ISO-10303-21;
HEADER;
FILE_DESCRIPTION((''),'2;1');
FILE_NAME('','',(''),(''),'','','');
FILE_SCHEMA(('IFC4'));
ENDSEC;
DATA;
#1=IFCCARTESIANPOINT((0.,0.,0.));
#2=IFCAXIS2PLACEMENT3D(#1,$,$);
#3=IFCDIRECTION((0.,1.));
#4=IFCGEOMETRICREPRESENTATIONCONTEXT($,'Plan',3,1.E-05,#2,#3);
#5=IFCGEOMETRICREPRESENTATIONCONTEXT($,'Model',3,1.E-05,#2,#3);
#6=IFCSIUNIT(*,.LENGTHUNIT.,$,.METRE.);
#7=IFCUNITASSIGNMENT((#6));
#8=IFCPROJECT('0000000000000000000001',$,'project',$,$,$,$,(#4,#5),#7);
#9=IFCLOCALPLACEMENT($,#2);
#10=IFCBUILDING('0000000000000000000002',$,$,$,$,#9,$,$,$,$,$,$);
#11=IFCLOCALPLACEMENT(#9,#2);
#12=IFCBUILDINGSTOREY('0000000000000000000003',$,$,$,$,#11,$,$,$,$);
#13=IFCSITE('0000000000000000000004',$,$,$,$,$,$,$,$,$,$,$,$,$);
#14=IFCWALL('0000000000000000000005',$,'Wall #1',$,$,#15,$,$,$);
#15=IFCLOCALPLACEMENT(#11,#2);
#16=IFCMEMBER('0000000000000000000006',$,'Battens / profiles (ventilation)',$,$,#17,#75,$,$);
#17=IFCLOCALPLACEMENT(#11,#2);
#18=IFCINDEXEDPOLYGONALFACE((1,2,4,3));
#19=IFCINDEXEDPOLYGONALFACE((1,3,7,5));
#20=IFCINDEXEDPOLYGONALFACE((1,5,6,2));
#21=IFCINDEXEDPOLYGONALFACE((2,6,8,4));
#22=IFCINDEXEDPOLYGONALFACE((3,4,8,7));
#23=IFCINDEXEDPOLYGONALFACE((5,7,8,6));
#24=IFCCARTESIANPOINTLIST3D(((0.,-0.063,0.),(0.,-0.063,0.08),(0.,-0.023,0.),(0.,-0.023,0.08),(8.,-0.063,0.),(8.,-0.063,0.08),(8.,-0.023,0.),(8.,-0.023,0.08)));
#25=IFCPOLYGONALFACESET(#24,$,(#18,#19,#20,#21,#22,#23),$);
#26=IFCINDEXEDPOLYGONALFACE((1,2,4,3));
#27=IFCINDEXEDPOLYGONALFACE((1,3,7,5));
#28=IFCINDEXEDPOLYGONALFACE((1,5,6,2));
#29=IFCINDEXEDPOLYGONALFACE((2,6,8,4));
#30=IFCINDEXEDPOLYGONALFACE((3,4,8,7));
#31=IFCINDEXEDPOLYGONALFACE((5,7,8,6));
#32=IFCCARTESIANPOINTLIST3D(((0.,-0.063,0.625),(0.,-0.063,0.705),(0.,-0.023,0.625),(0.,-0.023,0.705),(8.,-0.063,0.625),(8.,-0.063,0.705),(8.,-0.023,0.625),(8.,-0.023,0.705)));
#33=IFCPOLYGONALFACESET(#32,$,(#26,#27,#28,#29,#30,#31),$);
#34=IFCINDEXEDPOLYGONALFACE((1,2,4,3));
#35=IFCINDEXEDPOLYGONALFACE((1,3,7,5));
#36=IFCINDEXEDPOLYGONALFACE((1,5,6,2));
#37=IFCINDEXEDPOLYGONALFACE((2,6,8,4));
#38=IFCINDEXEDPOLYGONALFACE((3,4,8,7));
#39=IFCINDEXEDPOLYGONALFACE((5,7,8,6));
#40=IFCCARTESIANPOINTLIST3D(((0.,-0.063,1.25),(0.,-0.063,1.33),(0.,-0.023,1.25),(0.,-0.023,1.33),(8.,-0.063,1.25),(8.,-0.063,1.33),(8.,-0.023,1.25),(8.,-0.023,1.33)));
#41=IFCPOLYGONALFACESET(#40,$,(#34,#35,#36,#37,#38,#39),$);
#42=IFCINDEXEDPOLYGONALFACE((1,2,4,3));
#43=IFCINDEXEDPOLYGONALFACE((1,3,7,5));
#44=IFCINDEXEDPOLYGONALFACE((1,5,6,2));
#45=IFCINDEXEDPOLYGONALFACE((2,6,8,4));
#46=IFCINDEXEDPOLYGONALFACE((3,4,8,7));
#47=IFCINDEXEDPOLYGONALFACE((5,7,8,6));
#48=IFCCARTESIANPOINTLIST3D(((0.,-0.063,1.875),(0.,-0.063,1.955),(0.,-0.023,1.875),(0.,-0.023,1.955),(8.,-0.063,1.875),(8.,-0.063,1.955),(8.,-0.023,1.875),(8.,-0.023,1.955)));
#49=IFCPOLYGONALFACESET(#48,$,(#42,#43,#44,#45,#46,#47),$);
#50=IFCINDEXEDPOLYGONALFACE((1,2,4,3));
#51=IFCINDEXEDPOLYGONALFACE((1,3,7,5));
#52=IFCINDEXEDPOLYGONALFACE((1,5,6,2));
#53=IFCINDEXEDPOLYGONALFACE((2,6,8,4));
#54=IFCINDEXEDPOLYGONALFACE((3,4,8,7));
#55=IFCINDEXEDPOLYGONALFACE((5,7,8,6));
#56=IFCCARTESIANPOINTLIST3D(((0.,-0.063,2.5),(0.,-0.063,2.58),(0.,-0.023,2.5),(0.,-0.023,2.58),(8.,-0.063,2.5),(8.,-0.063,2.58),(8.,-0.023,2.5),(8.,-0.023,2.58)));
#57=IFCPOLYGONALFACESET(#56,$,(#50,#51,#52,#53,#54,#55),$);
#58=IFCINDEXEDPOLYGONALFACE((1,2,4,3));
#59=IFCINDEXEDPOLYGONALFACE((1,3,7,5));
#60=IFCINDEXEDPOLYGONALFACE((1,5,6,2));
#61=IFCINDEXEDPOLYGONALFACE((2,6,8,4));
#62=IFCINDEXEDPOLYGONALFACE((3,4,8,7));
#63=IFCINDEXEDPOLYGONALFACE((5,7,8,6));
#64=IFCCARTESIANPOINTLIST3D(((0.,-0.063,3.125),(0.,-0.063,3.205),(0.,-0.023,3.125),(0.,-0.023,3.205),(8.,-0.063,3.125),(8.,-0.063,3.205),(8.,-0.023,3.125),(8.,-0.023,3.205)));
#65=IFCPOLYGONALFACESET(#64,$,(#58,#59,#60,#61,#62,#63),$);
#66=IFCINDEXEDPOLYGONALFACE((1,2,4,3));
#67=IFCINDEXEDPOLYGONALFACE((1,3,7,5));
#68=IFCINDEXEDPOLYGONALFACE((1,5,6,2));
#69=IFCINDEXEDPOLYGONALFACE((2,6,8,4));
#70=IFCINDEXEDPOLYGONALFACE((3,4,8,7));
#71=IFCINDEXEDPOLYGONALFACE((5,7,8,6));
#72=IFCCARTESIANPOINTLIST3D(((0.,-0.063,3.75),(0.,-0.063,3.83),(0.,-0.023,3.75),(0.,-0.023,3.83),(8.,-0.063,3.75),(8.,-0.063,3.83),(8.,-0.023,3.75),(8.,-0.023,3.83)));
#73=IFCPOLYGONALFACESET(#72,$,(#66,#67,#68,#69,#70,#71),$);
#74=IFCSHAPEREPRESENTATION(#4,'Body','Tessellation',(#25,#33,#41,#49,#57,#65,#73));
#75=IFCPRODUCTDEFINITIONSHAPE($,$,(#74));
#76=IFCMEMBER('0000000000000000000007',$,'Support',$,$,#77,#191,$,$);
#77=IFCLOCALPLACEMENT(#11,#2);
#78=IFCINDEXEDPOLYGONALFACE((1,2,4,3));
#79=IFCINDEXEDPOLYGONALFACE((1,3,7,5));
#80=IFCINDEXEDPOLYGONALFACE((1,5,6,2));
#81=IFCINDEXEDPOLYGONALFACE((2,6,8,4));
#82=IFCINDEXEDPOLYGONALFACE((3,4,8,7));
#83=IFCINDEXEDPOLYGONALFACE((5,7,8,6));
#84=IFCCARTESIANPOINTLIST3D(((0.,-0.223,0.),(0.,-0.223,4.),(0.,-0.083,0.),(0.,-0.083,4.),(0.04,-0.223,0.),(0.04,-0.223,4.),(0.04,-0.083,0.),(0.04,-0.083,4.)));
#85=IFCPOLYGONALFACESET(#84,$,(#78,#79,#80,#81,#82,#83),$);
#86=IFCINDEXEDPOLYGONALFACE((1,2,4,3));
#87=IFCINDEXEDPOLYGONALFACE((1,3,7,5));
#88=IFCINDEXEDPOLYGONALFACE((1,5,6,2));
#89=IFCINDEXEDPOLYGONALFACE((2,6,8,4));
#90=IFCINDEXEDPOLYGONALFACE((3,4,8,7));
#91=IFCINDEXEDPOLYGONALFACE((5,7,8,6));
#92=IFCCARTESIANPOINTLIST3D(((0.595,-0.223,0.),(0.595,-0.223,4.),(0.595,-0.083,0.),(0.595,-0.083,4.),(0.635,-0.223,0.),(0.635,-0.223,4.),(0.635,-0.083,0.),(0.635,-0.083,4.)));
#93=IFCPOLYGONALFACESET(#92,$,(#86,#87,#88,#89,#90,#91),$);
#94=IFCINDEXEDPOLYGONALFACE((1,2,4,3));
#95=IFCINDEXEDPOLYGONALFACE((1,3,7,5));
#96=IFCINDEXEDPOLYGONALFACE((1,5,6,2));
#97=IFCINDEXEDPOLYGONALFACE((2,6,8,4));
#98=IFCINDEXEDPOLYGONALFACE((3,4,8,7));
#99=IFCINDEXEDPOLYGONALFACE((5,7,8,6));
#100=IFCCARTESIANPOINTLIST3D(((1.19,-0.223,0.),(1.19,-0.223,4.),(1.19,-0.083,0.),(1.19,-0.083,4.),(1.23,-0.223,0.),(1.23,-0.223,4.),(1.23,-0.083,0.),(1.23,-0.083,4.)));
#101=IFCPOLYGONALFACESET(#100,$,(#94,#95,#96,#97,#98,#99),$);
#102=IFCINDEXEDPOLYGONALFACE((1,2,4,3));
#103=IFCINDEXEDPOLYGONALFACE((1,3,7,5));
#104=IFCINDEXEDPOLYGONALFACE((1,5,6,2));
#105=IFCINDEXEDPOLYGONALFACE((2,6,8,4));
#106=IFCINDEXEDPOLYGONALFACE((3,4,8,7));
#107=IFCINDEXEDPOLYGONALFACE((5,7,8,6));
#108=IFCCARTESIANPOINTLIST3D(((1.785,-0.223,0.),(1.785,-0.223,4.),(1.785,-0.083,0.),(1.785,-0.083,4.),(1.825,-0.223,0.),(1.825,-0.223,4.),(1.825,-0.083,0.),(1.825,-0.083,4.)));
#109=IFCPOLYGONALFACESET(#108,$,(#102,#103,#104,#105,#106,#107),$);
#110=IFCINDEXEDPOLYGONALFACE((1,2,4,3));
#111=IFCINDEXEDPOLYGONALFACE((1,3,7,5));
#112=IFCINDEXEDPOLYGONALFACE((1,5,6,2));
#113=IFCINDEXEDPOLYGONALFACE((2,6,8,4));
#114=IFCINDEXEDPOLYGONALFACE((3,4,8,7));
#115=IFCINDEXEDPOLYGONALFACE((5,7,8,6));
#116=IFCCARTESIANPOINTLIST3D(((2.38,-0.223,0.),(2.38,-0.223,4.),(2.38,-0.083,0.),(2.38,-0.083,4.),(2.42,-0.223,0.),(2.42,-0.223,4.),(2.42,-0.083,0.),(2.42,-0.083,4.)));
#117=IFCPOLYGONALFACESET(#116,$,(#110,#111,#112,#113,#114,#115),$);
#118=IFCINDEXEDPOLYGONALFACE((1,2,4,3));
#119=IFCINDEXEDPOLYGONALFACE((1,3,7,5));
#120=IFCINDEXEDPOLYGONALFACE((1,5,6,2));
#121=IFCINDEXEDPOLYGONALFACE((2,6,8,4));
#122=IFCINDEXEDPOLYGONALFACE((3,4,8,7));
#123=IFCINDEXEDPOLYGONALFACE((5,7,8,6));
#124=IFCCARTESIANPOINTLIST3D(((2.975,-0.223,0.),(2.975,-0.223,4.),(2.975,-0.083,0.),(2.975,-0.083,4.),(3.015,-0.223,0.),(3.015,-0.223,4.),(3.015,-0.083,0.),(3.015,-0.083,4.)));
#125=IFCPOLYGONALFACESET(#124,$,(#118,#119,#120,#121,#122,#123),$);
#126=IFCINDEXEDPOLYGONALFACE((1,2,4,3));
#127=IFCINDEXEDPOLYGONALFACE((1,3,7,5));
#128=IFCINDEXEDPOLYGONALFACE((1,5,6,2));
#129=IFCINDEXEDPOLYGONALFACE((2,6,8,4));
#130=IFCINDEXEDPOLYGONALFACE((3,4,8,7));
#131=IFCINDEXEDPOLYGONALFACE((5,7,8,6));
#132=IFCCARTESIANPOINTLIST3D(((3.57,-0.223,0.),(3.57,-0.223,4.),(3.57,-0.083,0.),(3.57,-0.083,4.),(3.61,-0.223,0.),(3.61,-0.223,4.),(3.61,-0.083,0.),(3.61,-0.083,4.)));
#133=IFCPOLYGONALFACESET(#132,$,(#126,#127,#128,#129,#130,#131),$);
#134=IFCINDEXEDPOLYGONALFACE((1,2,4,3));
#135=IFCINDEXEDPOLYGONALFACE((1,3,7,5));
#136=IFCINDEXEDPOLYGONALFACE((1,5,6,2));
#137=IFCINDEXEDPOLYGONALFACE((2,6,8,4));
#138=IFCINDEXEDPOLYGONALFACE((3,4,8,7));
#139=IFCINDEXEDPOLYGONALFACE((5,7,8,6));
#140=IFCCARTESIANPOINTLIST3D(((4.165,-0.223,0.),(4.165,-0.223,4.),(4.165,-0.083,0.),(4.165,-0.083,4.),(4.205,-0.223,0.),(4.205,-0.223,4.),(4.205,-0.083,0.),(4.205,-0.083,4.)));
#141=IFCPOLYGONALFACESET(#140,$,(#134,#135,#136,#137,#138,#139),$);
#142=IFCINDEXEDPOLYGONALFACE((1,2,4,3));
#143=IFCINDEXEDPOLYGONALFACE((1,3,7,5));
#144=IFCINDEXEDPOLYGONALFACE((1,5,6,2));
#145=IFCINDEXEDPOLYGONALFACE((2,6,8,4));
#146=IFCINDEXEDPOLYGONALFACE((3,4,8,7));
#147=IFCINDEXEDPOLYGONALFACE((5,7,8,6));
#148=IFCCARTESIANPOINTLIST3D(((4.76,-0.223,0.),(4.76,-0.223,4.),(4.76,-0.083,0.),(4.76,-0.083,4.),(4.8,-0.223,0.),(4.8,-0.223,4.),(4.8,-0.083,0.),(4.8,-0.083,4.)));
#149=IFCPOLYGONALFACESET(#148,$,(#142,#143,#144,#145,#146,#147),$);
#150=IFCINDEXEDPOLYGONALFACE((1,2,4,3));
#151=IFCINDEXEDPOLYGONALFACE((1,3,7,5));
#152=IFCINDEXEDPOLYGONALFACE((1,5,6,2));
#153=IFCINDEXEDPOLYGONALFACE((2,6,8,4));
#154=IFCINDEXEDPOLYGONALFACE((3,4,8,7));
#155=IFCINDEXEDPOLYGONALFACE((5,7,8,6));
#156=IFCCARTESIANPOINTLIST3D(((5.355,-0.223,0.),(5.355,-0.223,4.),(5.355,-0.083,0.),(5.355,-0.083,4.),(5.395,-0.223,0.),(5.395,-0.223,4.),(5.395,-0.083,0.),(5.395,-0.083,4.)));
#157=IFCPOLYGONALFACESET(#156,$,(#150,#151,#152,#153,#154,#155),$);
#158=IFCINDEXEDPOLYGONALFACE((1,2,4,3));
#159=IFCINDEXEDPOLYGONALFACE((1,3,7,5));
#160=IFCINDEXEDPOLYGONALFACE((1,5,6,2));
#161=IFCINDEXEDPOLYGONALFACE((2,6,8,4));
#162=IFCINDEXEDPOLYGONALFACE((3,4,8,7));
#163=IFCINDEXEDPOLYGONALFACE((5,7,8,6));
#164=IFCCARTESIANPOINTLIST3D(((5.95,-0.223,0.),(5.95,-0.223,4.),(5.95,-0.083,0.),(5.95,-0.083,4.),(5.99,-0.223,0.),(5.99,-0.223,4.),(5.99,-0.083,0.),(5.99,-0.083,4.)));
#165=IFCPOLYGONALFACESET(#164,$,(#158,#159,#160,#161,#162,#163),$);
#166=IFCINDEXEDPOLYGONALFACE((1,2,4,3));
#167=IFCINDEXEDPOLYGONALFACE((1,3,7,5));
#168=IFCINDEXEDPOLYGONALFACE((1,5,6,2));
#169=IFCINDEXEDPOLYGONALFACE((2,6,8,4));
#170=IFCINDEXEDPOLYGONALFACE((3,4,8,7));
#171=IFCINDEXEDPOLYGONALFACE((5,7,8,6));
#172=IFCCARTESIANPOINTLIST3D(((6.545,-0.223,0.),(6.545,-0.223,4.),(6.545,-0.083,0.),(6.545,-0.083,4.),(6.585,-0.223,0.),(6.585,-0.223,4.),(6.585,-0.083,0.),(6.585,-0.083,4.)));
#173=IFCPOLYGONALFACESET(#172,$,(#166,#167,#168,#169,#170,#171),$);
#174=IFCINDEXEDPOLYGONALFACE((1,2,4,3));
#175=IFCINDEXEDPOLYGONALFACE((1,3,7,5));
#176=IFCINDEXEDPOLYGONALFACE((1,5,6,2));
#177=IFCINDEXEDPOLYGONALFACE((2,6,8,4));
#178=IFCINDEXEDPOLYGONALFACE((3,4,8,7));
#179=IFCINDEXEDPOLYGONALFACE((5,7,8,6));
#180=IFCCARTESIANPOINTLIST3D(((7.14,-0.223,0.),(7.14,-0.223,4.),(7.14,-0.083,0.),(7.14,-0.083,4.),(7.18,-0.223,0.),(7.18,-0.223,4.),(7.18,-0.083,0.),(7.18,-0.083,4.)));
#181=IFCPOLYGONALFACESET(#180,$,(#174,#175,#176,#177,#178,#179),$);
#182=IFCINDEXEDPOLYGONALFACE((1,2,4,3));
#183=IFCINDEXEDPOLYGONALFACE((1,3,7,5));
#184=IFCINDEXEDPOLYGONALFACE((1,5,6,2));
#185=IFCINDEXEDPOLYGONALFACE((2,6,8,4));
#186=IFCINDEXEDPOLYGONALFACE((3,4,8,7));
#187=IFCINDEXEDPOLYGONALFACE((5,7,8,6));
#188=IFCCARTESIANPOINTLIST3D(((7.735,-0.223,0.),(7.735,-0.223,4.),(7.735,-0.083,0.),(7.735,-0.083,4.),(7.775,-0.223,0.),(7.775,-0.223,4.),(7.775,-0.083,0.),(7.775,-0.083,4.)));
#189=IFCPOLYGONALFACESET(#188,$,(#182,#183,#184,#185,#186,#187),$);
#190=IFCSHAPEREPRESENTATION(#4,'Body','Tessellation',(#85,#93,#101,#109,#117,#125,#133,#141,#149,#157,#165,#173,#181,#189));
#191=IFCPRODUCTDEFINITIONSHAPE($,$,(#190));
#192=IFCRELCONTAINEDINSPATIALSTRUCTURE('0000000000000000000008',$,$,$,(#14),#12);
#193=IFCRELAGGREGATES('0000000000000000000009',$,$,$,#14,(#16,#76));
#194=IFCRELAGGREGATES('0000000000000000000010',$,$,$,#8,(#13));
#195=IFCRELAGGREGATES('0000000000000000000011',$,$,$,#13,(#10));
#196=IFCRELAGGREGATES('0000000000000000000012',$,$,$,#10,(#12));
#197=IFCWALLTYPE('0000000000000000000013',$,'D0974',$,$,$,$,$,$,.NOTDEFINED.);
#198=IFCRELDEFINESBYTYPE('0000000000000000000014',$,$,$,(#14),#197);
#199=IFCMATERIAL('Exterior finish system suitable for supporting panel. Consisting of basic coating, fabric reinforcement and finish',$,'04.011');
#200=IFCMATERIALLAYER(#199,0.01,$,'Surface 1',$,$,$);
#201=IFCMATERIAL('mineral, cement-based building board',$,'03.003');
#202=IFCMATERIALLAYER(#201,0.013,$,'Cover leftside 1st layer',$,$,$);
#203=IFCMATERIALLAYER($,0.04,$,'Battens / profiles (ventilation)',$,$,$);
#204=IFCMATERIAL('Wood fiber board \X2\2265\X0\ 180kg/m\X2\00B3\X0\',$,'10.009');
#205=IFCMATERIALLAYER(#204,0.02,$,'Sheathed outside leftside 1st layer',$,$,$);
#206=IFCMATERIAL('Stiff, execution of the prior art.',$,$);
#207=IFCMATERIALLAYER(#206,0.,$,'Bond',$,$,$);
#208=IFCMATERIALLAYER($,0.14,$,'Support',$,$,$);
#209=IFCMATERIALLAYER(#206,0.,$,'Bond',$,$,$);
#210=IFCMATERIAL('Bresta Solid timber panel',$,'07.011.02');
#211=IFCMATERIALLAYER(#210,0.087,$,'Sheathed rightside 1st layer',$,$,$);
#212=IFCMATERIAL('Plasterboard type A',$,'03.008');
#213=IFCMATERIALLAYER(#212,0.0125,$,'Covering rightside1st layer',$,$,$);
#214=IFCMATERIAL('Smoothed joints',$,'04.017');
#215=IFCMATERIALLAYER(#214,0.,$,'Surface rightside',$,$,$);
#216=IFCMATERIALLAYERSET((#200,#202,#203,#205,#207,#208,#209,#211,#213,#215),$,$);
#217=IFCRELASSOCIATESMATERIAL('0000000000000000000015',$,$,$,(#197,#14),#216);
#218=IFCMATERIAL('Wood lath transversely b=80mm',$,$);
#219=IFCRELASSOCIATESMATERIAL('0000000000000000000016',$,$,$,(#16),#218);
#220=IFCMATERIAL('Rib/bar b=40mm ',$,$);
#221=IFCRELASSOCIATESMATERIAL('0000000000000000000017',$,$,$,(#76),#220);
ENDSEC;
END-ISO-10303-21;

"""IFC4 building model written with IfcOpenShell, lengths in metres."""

from ifc_helpers import new_model, si_unit, direction, frame, frame_2d, origin, place, context, project, spatial, rectangle, extrude, material, layer, layer_set, type_object, element, aggregate, save


model = new_model("IFC4")

# Units and contexts
plan_context = context("Plan", 3, precision=1e-05, world=origin(), true_north=direction((0.0, 1.0)))
model_context = context("Model", 3, precision=1e-05, world=origin(), true_north=direction((0.0, 1.0)))
ifc_project = project(units=[si_unit("LENGTHUNIT", "METRE")], contexts=[plan_context, model_context])

# Site, building, storey
site = spatial("IfcSite", under=ifc_project)
building_placement = place(None, origin())
building = spatial("IfcBuilding", under=site, at=building_placement)
storey_placement = place(building_placement, origin())
storey = spatial("IfcBuildingStorey", under=building, at=storey_placement)

# Wall, members
ifc_material_1 = material(Name="Exterior finish system suitable for supporting panel. Consisting of basic coating, fabric reinforcement and finish", Category="04.011")
ifc_layer_1 = layer(ifc_material_1, 0.01, Name="Surface 1")
ifc_material_2 = material(Name="mineral, cement-based building board", Category="03.003")
ifc_layer_2 = layer(ifc_material_2, 0.013, Name="Cover leftside 1st layer")
ifc_layer_3 = layer(None, 0.04, Name="Battens / profiles (ventilation)")
ifc_material_3 = material(Name="Wood fiber board ≥ 180kg/m³", Category="10.009")
ifc_layer_4 = layer(ifc_material_3, 0.02, Name="Sheathed outside leftside 1st layer")
ifc_material_4 = material(Name="Stiff, execution of the prior art.")
ifc_layer_5 = layer(ifc_material_4, 0.0, Name="Bond")
ifc_layer_6 = layer(None, 0.14, Name="Support")
ifc_layer_7 = layer(ifc_material_4, 0.0, Name="Bond")
ifc_material_5 = material(Name="Bresta Solid timber panel", Category="07.011.02")
ifc_layer_8 = layer(ifc_material_5, 0.087, Name="Sheathed rightside 1st layer")
ifc_material_6 = material(Name="Plasterboard type A", Category="03.008")
ifc_layer_9 = layer(ifc_material_6, 0.0125, Name="Covering rightside1st layer")
ifc_material_7 = material(Name="Smoothed joints", Category="04.017")
ifc_layer_10 = layer(ifc_material_7, 0.0, Name="Surface rightside")
ifc_layer_set = layer_set([ifc_layer_1, ifc_layer_2, ifc_layer_3, ifc_layer_4, ifc_layer_5, ifc_layer_6, ifc_layer_7, ifc_layer_8, ifc_layer_9, ifc_layer_10])
wall_type = type_object("IfcWallType", Name="D0974", PredefinedType="NOTDEFINED", material=ifc_layer_set)
wall_placement = place(None, frame((0.0, 0.0, 0.0), z_axis=(0.0, -1.0, 0.0), x_axis=(1.0, 0.0, 0.0)))
wall = element("IfcWall", 1, at=wall_placement, inside=storey, type_object=wall_type, material=ifc_layer_set, Name="Wall #1")
ifc_material_8 = material(Name="Wood lath transversely b=80mm")
member_1_placement = place(wall_placement, origin())
member_1 = element("IfcMember", 2, at=member_1_placement, material=ifc_material_8, Name="Battens / profiles (ventilation)", context=plan_context, shape_type="SweptSolid", body=[
    extrude(rectangle(XDim=0.08, YDim=0.04, at=frame_2d((0.04, 0.02), x_axis=(1.0, 0.0))), frame((0.0, 0.0, 0.023), z_axis=(1.0, 0.0, 0.0), x_axis=(0.0, 1.0, 0.0)), (0.0, 0.0, 1.0), 8.0),
    extrude(rectangle(XDim=0.08, YDim=0.04, at=frame_2d((0.04, 0.02), x_axis=(1.0, 0.0))), frame((0.0, 0.625, 0.023), z_axis=(1.0, 0.0, 0.0), x_axis=(0.0, 1.0, 0.0)), (0.0, 0.0, 1.0), 8.0),
    extrude(rectangle(XDim=0.08, YDim=0.04, at=frame_2d((0.04, 0.02), x_axis=(1.0, 0.0))), frame((0.0, 1.25, 0.023), z_axis=(1.0, 0.0, 0.0), x_axis=(0.0, 1.0, 0.0)), (0.0, 0.0, 1.0), 8.0),
    extrude(rectangle(XDim=0.08, YDim=0.04, at=frame_2d((0.04, 0.02), x_axis=(1.0, 0.0))), frame((0.0, 1.875, 0.023), z_axis=(1.0, 0.0, 0.0), x_axis=(0.0, 1.0, 0.0)), (0.0, 0.0, 1.0), 8.0),
    extrude(rectangle(XDim=0.08, YDim=0.04, at=frame_2d((0.04, 0.02), x_axis=(1.0, 0.0))), frame((0.0, 2.5, 0.023), z_axis=(1.0, 0.0, 0.0), x_axis=(0.0, 1.0, 0.0)), (0.0, 0.0, 1.0), 8.0),
    extrude(rectangle(XDim=0.08, YDim=0.04, at=frame_2d((0.04, 0.02), x_axis=(1.0, 0.0))), frame((0.0, 3.125, 0.023), z_axis=(1.0, 0.0, 0.0), x_axis=(0.0, 1.0, 0.0)), (0.0, 0.0, 1.0), 8.0),
    extrude(rectangle(XDim=0.08, YDim=0.04, at=frame_2d((0.04, 0.02), x_axis=(1.0, 0.0))), frame((0.0, 3.75, 0.023), z_axis=(1.0, 0.0, 0.0), x_axis=(0.0, 1.0, 0.0)), (0.0, 0.0, 1.0), 8.0),
])
ifc_material_9 = material(Name="Rib/bar b=40mm ")
member_2_placement = place(wall_placement, origin())
member_2 = element("IfcMember", 3, at=member_2_placement, material=ifc_material_9, Name="Support", context=plan_context, shape_type="SweptSolid", body=[
    extrude(rectangle(XDim=0.04, YDim=0.14, at=frame_2d((0.02, 0.07), x_axis=(1.0, 0.0))), frame((0.0, 4.0, 0.083), z_axis=(0.0, -1.0, 0.0), x_axis=(1.0, 0.0, 0.0)), (0.0, 0.0, 1.0), 4.0),
    extrude(rectangle(XDim=0.04, YDim=0.14, at=frame_2d((0.02, 0.07), x_axis=(1.0, 0.0))), frame((0.595, 4.0, 0.083), z_axis=(0.0, -1.0, 0.0), x_axis=(1.0, 0.0, 0.0)), (0.0, 0.0, 1.0), 4.0),
    extrude(rectangle(XDim=0.04, YDim=0.14, at=frame_2d((0.02, 0.07), x_axis=(1.0, 0.0))), frame((1.19, 4.0, 0.083), z_axis=(0.0, -1.0, 0.0), x_axis=(1.0, 0.0, 0.0)), (0.0, 0.0, 1.0), 4.0),
    extrude(rectangle(XDim=0.04, YDim=0.14, at=frame_2d((0.02, 0.07), x_axis=(1.0, 0.0))), frame((1.785, 4.0, 0.083), z_axis=(0.0, -1.0, 0.0), x_axis=(1.0, 0.0, 0.0)), (0.0, 0.0, 1.0), 4.0),
    extrude(rectangle(XDim=0.04, YDim=0.14, at=frame_2d((0.02, 0.07), x_axis=(1.0, 0.0))), frame((2.38, 4.0, 0.083), z_axis=(0.0, -1.0, 0.0), x_axis=(1.0, 0.0, 0.0)), (0.0, 0.0, 1.0), 4.0),
    extrude(rectangle(XDim=0.04, YDim=0.14, at=frame_2d((0.02, 0.07), x_axis=(1.0, 0.0))), frame((2.975, 4.0, 0.083), z_axis=(0.0, -1.0, 0.0), x_axis=(1.0, 0.0, 0.0)), (0.0, 0.0, 1.0), 4.0),
    extrude(rectangle(XDim=0.04, YDim=0.14, at=frame_2d((0.02, 0.07), x_axis=(1.0, 0.0))), frame((3.57, 4.0, 0.083), z_axis=(0.0, -1.0, 0.0), x_axis=(1.0, 0.0, 0.0)), (0.0, 0.0, 1.0), 4.0),
    extrude(rectangle(XDim=0.04, YDim=0.14, at=frame_2d((0.02, 0.07), x_axis=(1.0, 0.0))), frame((4.165, 4.0, 0.083), z_axis=(0.0, -1.0, 0.0), x_axis=(1.0, 0.0, 0.0)), (0.0, 0.0, 1.0), 4.0),
    extrude(rectangle(XDim=0.04, YDim=0.14, at=frame_2d((0.02, 0.07), x_axis=(1.0, 0.0))), frame((4.76, 4.0, 0.083), z_axis=(0.0, -1.0, 0.0), x_axis=(1.0, 0.0, 0.0)), (0.0, 0.0, 1.0), 4.0),
    extrude(rectangle(XDim=0.04, YDim=0.14, at=frame_2d((0.02, 0.07), x_axis=(1.0, 0.0))), frame((5.355, 4.0, 0.083), z_axis=(0.0, -1.0, 0.0), x_axis=(1.0, 0.0, 0.0)), (0.0, 0.0, 1.0), 4.0),
    extrude(rectangle(XDim=0.04, YDim=0.14, at=frame_2d((0.02, 0.07), x_axis=(1.0, 0.0))), frame((5.95, 4.0, 0.083), z_axis=(0.0, -1.0, 0.0), x_axis=(1.0, 0.0, 0.0)), (0.0, 0.0, 1.0), 4.0),
    extrude(rectangle(XDim=0.04, YDim=0.14, at=frame_2d((0.02, 0.07), x_axis=(1.0, 0.0))), frame((6.545, 4.0, 0.083), z_axis=(0.0, -1.0, 0.0), x_axis=(1.0, 0.0, 0.0)), (0.0, 0.0, 1.0), 4.0),
    extrude(rectangle(XDim=0.04, YDim=0.14, at=frame_2d((0.02, 0.07), x_axis=(1.0, 0.0))), frame((7.14, 4.0, 0.083), z_axis=(0.0, -1.0, 0.0), x_axis=(1.0, 0.0, 0.0)), (0.0, 0.0, 1.0), 4.0),
    extrude(rectangle(XDim=0.04, YDim=0.14, at=frame_2d((0.02, 0.07), x_axis=(1.0, 0.0))), frame((7.735, 4.0, 0.083), z_axis=(0.0, -1.0, 0.0), x_axis=(1.0, 0.0, 0.0)), (0.0, 0.0, 1.0), 4.0),
])
aggregate(wall, [member_1, member_2])

save(model, "model.ifc")
